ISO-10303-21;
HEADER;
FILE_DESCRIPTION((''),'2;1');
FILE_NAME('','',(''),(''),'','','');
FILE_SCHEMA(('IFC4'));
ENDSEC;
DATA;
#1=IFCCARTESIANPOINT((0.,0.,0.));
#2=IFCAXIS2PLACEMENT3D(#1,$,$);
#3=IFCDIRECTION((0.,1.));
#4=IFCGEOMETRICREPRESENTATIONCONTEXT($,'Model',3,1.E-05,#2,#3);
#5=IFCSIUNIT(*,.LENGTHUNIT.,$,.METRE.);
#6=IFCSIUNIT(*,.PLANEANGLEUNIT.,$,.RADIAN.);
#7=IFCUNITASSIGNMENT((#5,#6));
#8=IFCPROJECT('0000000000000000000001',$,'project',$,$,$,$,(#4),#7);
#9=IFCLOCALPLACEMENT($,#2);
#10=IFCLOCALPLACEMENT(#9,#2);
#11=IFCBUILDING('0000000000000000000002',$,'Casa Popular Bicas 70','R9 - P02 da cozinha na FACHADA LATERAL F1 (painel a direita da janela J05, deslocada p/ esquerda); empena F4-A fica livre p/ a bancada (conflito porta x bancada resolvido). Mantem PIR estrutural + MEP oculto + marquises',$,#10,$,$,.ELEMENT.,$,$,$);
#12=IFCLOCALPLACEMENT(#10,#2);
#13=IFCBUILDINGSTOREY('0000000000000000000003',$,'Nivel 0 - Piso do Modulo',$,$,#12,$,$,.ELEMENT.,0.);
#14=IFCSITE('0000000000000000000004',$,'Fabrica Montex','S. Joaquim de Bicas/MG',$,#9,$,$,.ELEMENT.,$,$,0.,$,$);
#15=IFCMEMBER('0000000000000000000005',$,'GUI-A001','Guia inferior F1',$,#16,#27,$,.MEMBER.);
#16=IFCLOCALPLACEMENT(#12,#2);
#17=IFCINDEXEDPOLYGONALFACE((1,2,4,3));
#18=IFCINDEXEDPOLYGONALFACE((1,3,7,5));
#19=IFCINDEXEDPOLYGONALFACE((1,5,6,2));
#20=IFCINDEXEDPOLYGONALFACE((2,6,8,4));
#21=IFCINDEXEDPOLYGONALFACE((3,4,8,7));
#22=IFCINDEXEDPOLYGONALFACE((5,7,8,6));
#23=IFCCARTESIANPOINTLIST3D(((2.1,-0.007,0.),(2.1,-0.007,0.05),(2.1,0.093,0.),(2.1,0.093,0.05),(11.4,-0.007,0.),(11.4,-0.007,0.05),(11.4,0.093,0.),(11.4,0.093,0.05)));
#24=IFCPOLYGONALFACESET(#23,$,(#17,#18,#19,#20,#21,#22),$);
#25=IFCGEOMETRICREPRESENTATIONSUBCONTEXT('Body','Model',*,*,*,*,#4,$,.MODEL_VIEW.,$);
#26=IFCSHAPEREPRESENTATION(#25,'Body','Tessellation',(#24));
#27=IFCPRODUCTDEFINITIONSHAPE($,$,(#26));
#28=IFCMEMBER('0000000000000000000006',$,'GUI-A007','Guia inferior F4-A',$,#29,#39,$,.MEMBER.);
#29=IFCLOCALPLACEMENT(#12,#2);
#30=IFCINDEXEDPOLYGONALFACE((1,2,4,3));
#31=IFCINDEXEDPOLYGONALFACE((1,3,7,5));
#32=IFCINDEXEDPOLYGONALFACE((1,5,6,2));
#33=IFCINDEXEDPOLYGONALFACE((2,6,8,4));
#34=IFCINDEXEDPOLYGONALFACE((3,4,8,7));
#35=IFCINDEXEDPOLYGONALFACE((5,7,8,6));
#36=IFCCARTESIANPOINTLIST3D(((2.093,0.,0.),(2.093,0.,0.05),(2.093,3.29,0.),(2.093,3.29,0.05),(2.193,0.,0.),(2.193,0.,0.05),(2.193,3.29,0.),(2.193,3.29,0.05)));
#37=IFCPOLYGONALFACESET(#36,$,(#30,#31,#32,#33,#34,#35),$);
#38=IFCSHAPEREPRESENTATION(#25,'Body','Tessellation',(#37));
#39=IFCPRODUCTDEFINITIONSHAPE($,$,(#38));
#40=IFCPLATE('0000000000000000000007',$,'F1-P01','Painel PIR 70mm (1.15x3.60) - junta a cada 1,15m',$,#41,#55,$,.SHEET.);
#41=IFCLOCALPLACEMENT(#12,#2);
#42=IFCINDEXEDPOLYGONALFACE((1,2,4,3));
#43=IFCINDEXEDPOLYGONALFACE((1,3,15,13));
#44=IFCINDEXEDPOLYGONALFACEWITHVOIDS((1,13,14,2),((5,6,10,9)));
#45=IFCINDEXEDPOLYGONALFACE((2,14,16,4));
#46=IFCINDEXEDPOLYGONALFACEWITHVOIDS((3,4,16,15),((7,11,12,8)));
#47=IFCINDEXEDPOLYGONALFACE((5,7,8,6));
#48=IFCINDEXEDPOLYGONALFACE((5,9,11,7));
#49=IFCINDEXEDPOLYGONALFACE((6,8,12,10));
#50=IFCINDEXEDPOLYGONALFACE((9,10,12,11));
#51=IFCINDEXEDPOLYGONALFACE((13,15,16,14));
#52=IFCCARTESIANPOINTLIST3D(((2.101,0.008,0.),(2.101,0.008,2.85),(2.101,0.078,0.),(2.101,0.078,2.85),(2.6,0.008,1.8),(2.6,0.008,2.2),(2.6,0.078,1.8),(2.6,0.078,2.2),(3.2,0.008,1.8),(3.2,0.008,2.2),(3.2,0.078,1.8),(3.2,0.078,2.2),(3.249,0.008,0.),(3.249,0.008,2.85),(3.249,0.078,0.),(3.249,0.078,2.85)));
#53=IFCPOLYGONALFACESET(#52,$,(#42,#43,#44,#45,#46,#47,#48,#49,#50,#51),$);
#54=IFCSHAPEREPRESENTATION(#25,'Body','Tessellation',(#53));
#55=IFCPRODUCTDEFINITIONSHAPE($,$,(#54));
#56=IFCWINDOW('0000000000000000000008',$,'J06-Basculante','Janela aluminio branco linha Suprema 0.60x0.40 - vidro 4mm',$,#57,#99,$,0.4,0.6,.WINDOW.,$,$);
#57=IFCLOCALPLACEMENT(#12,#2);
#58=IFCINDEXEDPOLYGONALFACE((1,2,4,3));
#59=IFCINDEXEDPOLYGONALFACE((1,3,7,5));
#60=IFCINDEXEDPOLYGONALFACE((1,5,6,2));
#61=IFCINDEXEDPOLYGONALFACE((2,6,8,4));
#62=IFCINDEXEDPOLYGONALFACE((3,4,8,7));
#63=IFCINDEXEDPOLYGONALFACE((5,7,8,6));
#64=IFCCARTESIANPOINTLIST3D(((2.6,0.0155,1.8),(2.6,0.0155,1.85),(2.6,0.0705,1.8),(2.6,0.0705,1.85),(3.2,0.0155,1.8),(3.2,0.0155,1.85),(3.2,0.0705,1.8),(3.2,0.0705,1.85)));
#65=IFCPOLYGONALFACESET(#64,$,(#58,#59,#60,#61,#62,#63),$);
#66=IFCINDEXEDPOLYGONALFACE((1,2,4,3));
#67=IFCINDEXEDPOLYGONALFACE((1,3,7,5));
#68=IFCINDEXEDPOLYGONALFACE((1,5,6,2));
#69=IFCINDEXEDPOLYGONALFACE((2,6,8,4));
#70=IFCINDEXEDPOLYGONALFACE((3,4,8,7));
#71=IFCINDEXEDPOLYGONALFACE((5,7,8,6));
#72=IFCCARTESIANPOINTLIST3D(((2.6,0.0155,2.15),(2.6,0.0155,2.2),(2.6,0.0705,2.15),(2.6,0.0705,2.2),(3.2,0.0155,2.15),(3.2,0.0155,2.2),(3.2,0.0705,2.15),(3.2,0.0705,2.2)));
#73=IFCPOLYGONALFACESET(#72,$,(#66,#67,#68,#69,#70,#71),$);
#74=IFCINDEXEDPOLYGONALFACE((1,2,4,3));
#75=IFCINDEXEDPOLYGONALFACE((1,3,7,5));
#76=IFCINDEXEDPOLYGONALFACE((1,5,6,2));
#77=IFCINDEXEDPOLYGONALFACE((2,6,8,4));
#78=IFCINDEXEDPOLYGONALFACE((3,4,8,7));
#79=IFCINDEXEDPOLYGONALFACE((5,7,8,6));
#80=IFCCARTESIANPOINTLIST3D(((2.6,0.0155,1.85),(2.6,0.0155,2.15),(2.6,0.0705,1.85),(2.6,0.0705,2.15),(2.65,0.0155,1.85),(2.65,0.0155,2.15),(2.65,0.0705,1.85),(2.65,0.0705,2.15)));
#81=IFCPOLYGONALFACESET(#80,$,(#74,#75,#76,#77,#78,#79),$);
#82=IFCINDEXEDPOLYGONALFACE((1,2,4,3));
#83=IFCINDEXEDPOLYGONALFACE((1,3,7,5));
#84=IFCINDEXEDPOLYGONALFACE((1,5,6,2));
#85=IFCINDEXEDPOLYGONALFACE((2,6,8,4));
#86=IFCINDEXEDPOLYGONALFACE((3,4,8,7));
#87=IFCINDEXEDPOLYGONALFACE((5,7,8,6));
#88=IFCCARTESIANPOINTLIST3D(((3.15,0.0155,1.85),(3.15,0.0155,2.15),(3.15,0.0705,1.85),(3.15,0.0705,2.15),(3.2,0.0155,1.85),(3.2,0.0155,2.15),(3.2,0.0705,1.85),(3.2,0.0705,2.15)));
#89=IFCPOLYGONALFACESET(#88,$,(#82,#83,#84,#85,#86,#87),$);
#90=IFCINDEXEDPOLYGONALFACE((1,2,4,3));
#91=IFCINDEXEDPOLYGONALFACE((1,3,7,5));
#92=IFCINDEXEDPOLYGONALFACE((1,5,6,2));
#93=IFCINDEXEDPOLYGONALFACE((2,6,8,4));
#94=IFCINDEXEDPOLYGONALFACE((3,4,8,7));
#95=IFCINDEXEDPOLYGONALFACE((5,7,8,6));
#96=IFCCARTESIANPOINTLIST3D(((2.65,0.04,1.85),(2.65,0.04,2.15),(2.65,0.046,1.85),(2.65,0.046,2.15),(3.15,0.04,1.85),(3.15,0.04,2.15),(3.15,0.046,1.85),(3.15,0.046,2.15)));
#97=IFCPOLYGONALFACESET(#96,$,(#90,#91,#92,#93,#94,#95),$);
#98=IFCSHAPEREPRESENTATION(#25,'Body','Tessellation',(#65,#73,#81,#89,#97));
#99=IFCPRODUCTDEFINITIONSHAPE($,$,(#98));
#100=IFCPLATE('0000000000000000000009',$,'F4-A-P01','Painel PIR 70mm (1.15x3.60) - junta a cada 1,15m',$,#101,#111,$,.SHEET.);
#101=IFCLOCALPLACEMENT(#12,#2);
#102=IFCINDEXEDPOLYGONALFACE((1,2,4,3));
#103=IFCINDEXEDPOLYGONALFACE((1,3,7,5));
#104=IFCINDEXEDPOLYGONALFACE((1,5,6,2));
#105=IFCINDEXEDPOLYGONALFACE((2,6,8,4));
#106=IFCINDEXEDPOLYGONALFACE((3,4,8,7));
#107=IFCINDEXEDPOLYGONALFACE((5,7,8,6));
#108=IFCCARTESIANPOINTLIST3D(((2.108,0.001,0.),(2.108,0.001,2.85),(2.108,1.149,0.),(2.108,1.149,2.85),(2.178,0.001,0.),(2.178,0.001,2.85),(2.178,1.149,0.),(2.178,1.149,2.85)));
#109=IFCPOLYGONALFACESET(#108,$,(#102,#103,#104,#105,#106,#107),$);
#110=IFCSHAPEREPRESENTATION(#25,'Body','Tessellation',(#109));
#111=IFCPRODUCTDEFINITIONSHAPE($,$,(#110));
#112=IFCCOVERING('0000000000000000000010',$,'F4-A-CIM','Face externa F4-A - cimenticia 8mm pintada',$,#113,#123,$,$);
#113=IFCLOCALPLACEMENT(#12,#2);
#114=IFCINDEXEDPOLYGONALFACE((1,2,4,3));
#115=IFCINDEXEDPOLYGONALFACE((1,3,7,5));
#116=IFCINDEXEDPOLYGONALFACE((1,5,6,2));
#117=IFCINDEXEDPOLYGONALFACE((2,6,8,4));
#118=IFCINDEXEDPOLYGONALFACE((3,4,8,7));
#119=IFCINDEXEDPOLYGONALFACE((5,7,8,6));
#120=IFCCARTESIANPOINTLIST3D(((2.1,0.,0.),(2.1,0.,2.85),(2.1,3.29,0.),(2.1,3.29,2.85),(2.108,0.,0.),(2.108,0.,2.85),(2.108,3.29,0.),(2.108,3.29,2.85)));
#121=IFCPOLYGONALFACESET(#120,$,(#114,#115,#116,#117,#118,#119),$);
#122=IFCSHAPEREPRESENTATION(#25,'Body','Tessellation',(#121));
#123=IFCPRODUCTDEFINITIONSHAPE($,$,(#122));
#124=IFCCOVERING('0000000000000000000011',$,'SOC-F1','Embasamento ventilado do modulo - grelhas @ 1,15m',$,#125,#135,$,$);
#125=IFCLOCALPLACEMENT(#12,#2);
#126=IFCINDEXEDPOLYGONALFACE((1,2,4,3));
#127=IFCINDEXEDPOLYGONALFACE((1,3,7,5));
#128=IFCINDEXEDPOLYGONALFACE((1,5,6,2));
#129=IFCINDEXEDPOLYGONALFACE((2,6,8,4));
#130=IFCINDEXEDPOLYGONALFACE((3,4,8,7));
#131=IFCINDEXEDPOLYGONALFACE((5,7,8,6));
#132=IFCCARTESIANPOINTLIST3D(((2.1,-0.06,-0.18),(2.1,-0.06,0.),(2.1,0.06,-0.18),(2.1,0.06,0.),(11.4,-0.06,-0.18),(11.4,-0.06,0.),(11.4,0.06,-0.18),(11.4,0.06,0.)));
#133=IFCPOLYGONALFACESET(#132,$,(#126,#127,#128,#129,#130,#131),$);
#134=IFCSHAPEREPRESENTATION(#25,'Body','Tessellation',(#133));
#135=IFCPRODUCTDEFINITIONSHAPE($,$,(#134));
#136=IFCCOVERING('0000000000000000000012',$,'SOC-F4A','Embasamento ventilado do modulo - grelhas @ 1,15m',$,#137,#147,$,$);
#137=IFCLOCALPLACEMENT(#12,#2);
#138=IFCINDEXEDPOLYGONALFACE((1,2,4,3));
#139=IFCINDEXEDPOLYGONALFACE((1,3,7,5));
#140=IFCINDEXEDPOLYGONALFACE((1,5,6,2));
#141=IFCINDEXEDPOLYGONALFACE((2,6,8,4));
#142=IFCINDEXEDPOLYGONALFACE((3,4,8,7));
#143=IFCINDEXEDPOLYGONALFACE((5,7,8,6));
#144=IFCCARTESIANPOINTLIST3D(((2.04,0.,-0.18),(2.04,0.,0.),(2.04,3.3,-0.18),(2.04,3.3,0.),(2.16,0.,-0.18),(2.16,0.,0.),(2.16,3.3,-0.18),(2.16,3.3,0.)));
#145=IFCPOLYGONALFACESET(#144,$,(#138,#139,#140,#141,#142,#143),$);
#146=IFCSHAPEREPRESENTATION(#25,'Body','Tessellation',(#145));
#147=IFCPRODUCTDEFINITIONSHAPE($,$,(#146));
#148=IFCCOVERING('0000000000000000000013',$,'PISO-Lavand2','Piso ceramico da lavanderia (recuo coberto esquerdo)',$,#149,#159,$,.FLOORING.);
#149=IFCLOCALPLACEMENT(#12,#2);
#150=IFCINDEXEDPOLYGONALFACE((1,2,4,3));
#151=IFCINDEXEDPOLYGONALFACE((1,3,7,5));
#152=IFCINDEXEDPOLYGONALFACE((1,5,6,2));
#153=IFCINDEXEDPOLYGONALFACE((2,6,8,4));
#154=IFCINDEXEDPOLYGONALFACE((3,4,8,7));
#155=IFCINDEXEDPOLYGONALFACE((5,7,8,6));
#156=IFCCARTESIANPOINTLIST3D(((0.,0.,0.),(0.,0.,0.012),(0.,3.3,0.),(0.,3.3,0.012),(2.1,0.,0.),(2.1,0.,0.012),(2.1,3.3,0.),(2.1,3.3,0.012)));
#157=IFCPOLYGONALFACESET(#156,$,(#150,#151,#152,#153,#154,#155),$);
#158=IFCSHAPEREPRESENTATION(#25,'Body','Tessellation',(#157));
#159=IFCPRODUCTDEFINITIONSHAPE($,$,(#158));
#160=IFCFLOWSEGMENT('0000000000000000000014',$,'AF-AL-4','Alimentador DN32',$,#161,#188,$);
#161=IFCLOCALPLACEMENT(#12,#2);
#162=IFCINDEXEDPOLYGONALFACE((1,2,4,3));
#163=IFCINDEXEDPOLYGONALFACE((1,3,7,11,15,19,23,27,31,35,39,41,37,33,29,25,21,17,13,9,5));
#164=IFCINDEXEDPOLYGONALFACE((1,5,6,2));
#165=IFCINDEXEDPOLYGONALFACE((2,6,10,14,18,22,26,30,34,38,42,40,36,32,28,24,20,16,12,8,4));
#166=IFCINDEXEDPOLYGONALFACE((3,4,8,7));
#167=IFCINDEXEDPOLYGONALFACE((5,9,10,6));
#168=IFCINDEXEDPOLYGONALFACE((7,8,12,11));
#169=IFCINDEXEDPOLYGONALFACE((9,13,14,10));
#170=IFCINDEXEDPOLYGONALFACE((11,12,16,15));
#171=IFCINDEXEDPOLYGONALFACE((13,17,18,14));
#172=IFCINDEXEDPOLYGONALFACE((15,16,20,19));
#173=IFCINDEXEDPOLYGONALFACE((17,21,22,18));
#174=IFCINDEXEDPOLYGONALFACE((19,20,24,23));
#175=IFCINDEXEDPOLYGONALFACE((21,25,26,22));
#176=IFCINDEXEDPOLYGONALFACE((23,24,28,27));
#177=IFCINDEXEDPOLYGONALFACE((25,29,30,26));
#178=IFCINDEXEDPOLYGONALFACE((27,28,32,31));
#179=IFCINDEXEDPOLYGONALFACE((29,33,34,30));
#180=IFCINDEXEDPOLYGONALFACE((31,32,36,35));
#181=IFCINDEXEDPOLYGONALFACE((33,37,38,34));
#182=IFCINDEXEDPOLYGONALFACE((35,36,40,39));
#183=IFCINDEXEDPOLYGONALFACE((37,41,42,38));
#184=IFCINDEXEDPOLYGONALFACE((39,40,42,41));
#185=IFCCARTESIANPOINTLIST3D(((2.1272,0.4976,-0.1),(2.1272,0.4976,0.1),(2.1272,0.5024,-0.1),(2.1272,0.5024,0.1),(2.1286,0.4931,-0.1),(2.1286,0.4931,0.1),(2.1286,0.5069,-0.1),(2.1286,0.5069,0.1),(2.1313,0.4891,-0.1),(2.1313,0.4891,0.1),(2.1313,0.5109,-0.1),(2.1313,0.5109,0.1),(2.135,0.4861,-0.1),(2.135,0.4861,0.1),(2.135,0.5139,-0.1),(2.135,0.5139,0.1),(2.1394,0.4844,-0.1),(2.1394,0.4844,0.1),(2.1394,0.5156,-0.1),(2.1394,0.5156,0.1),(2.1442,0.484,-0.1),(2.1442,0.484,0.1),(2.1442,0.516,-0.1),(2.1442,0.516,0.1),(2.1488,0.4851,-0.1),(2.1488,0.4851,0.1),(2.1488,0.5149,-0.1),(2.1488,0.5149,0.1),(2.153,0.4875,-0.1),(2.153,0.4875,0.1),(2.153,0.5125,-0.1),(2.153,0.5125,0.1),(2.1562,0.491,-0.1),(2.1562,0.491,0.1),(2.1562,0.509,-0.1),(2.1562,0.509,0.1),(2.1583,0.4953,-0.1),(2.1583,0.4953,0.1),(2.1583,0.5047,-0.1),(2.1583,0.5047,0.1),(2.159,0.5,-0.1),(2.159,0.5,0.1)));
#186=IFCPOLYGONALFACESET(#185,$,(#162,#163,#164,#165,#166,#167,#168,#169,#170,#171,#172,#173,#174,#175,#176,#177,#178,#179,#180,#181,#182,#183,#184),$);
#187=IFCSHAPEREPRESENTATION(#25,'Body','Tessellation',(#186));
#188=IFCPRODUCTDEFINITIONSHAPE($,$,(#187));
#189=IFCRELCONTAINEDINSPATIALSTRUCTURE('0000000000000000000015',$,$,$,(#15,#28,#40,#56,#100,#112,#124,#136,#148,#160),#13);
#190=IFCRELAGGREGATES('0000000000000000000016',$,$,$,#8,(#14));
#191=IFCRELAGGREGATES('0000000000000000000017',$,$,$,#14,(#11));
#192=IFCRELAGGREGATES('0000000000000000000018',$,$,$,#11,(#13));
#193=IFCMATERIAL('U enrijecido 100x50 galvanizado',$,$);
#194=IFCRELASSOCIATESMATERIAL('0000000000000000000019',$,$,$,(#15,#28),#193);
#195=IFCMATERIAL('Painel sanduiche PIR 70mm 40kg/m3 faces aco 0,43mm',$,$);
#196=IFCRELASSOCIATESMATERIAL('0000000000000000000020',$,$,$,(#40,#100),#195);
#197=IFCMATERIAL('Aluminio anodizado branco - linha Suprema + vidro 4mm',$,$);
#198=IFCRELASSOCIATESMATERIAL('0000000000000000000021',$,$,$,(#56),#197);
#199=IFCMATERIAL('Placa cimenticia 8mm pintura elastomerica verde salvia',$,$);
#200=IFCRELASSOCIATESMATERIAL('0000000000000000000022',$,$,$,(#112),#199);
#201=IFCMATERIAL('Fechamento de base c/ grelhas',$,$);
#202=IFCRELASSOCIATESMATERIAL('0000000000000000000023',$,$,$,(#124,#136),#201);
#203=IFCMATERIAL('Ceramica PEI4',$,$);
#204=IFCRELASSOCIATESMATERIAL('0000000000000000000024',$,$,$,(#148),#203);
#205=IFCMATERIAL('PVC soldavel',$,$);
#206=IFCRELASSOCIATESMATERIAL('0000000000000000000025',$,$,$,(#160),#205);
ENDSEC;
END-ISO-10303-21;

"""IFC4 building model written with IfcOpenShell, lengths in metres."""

from ifc_helpers import new_model, si_unit, direction, frame, frame_2d, origin, origin_2d, place, context, subcontext, project, spatial, rectangle, circle, extrude, material, element, fill, save


model = new_model("IFC4")

# Units and contexts
model_context = context("Model", 3, precision=1e-05, world=origin(), true_north=direction((0.0, 1.0)))
body_context = subcontext(model_context, "Body", "Model", "MODEL_VIEW")
ifc_project = project(units=[si_unit("LENGTHUNIT", "METRE"), si_unit("PLANEANGLEUNIT", "RADIAN")], contexts=[model_context])

# Site, building, storey
site_placement = place(None, origin())
site = spatial("IfcSite", under=ifc_project, at=site_placement, Name="Fabrica Montex", Description="S. Joaquim de Bicas/MG", CompositionType="ELEMENT", RefElevation=0.0)
building_placement = place(site_placement, origin())
building = spatial("IfcBuilding", under=site, at=building_placement, Name="Casa Popular Bicas 70", Description="R9 - P02 da cozinha na FACHADA LATERAL F1 (painel a direita da janela J05, deslocada p/ esquerda); empena F4-A fica livre p/ a bancada (conflito porta x bancada resolvido). Mantem PIR estrutural + MEP oculto + marquises", CompositionType="ELEMENT")
storey_placement = place(building_placement, origin())
storey = spatial("IfcBuildingStorey", under=building, at=storey_placement, Name="Nivel 0 - Piso do Modulo", CompositionType="ELEMENT", Elevation=0.0)

# Members
ifc_material_1 = material(Name="U enrijecido 100x50 galvanizado")
member_1_placement = place(storey_placement, frame((2.1, 0.043, 0.025), z_axis=(1.0, 0.0, 0.0), x_axis=(0.0, 0.0, 1.0)))
element("IfcMember", 1, at=member_1_placement, inside=storey, material=ifc_material_1, Name="GUI-A001", Description="Guia inferior F1", PredefinedType="MEMBER", context=body_context, shape_type="SweptSolid", body=[
    extrude(rectangle(XDim=0.05, YDim=0.1, at=origin_2d()), origin(), (0.0, 0.0, 1.0), 9.3),
])
member_2_placement = place(storey_placement, frame((2.143, 0.0, 0.025), z_axis=(0.0, 1.0, 0.0), x_axis=(0.0, 0.0, 1.0)))
element("IfcMember", 2, at=member_2_placement, inside=storey, material=ifc_material_1, Name="GUI-A007", Description="Guia inferior F4-A", PredefinedType="MEMBER", context=body_context, shape_type="SweptSolid", body=[
    extrude(rectangle(XDim=0.05, YDim=0.1, at=origin_2d()), origin(), (0.0, 0.0, 1.0), 3.29),
])

# Plate, opening, window
ifc_material_2 = material(Name="Painel sanduiche PIR 70mm 40kg/m3 faces aco 0,43mm")
plate_1_placement = place(storey_placement, frame((2.101, 0.043, 0.0), x_axis=(1.0, 0.0, 0.0)))
plate_1 = element("IfcPlate", 3, at=plate_1_placement, inside=storey, material=ifc_material_2, Name="F1-P01", Description="Painel PIR 70mm (1.15x3.60) - junta a cada 1,15m", PredefinedType="SHEET", context=body_context, shape_type="SweptSolid", body=[
    extrude(rectangle(XDim=1.148, YDim=0.07, at=frame_2d((0.574, 0.0))), origin(), (0.0, 0.0, 1.0), 2.85),
])
opening_1_placement = place(storey_placement, frame((2.9, 0.043, 1.8)))
opening_1 = element("IfcOpeningElement", 4, at=opening_1_placement, cuts=plate_1, PredefinedType="OPENING", context=body_context, shape_type="SweptSolid", body=[
    extrude(rectangle(XDim=0.6, YDim=0.1, at=origin_2d()), origin(), (0.0, 0.0, 1.0), 0.4),
])
ifc_material_3 = material(Name="Aluminio anodizado branco - linha Suprema + vidro 4mm")
window_placement = place(storey_placement, frame((2.6, 0.043, 1.8), x_axis=(1.0, 0.0, 0.0)))
window = element("IfcWindow", 5, at=window_placement, inside=storey, material=ifc_material_3, Name="J06-Basculante", Description="Janela aluminio branco linha Suprema 0.60x0.40 - vidro 4mm", OverallHeight=0.4, OverallWidth=0.6, PredefinedType="WINDOW", context=body_context, shape_type="SweptSolid", body=[
    extrude(rectangle(XDim=0.6, YDim=0.055, at=frame_2d((0.3, 0.0))), origin(), (0.0, 0.0, 1.0), 0.05),
    extrude(rectangle(XDim=0.6, YDim=0.055, at=frame_2d((0.3, 0.0))), frame((0.0, 0.0, 0.35)), (0.0, 0.0, 1.0), 0.05),
    extrude(rectangle(XDim=0.05, YDim=0.055, at=frame_2d((0.025, 0.0))), frame((0.0, 0.0, 0.05)), (0.0, 0.0, 1.0), 0.3),
    extrude(rectangle(XDim=0.05, YDim=0.055, at=frame_2d((0.575, 0.0))), frame((0.0, 0.0, 0.05)), (0.0, 0.0, 1.0), 0.3),
    extrude(rectangle(XDim=0.5, YDim=0.006, at=frame_2d((0.3, 0.0))), frame((0.0, 0.0, 0.05)), (0.0, 0.0, 1.0), 0.3),
])
fill(opening_1, window)

# Plate
plate_2_placement = place(storey_placement, frame((2.143, 0.001, 0.0), x_axis=(0.0, 1.0, 0.0)))
element("IfcPlate", 6, at=plate_2_placement, inside=storey, material=ifc_material_2, Name="F4-A-P01", Description="Painel PIR 70mm (1.15x3.60) - junta a cada 1,15m", PredefinedType="SHEET", context=body_context, shape_type="SweptSolid", body=[
    extrude(rectangle(XDim=1.148, YDim=0.07, at=frame_2d((0.574, 0.0))), origin(), (0.0, 0.0, 1.0), 2.85),
])

# Shared definitions
ifc_material_4 = material(Name="Placa cimenticia 8mm pintura elastomerica verde salvia")

# Coverings
covering_1_placement = place(storey_placement, frame((2.104, 0.0, 0.0), x_axis=(0.0, 1.0, 0.0)))
element("IfcCovering", 7, at=covering_1_placement, inside=storey, material=ifc_material_4, Name="F4-A-CIM", Description="Face externa F4-A - cimenticia 8mm pintada", context=body_context, shape_type="SweptSolid", body=[
    extrude(rectangle(XDim=3.29, YDim=0.008, at=frame_2d((1.645, 0.0))), origin(), (0.0, 0.0, 1.0), 2.85),
])
ifc_material_5 = material(Name="Fechamento de base c/ grelhas")
covering_2_placement = place(storey_placement, frame((2.1, 0.0, -0.18), x_axis=(1.0, 0.0, 0.0)))
element("IfcCovering", 8, at=covering_2_placement, inside=storey, material=ifc_material_5, Name="SOC-F1", Description="Embasamento ventilado do modulo - grelhas @ 1,15m", context=body_context, shape_type="SweptSolid", body=[
    extrude(rectangle(XDim=9.3, YDim=0.12, at=frame_2d((4.65, 0.0))), origin(), (0.0, 0.0, 1.0), 0.18),
])
covering_3_placement = place(storey_placement, frame((2.1, 0.0, -0.18), x_axis=(0.0, 1.0, 0.0)))
element("IfcCovering", 9, at=covering_3_placement, inside=storey, material=ifc_material_5, Name="SOC-F4A", Description="Embasamento ventilado do modulo - grelhas @ 1,15m", context=body_context, shape_type="SweptSolid", body=[
    extrude(rectangle(XDim=3.3, YDim=0.12, at=frame_2d((1.65, 0.0))), origin(), (0.0, 0.0, 1.0), 0.18),
])
ifc_material_6 = material(Name="Ceramica PEI4")
covering_4_placement = place(storey_placement, origin())
element("IfcCovering", 10, at=covering_4_placement, inside=storey, material=ifc_material_6, Name="PISO-Lavand2", Description="Piso ceramico da lavanderia (recuo coberto esquerdo)", PredefinedType="FLOORING", context=body_context, shape_type="SweptSolid", body=[
    extrude(rectangle(XDim=2.1, YDim=3.3, at=frame_2d((1.05, 1.65))), origin(), (0.0, 0.0, 1.0), 0.012),
])

# Flow segment
ifc_material_7 = material(Name="PVC soldavel")
flow_segment_1_placement = place(storey_placement, frame((2.143, 0.5, -0.1), z_axis=(0.0, 0.0, 1.0), x_axis=(1.0, 0.0, 0.0)))
element("IfcFlowSegment", 11, at=flow_segment_1_placement, inside=storey, material=ifc_material_7, Name="AF-AL-4", Description="Alimentador DN32", context=body_context, shape_type="SweptSolid", body=[
    extrude(circle(Radius=0.016, at=origin_2d()), origin(), (0.0, 0.0, 1.0), 0.2),
])

save(model, "model.ifc")
